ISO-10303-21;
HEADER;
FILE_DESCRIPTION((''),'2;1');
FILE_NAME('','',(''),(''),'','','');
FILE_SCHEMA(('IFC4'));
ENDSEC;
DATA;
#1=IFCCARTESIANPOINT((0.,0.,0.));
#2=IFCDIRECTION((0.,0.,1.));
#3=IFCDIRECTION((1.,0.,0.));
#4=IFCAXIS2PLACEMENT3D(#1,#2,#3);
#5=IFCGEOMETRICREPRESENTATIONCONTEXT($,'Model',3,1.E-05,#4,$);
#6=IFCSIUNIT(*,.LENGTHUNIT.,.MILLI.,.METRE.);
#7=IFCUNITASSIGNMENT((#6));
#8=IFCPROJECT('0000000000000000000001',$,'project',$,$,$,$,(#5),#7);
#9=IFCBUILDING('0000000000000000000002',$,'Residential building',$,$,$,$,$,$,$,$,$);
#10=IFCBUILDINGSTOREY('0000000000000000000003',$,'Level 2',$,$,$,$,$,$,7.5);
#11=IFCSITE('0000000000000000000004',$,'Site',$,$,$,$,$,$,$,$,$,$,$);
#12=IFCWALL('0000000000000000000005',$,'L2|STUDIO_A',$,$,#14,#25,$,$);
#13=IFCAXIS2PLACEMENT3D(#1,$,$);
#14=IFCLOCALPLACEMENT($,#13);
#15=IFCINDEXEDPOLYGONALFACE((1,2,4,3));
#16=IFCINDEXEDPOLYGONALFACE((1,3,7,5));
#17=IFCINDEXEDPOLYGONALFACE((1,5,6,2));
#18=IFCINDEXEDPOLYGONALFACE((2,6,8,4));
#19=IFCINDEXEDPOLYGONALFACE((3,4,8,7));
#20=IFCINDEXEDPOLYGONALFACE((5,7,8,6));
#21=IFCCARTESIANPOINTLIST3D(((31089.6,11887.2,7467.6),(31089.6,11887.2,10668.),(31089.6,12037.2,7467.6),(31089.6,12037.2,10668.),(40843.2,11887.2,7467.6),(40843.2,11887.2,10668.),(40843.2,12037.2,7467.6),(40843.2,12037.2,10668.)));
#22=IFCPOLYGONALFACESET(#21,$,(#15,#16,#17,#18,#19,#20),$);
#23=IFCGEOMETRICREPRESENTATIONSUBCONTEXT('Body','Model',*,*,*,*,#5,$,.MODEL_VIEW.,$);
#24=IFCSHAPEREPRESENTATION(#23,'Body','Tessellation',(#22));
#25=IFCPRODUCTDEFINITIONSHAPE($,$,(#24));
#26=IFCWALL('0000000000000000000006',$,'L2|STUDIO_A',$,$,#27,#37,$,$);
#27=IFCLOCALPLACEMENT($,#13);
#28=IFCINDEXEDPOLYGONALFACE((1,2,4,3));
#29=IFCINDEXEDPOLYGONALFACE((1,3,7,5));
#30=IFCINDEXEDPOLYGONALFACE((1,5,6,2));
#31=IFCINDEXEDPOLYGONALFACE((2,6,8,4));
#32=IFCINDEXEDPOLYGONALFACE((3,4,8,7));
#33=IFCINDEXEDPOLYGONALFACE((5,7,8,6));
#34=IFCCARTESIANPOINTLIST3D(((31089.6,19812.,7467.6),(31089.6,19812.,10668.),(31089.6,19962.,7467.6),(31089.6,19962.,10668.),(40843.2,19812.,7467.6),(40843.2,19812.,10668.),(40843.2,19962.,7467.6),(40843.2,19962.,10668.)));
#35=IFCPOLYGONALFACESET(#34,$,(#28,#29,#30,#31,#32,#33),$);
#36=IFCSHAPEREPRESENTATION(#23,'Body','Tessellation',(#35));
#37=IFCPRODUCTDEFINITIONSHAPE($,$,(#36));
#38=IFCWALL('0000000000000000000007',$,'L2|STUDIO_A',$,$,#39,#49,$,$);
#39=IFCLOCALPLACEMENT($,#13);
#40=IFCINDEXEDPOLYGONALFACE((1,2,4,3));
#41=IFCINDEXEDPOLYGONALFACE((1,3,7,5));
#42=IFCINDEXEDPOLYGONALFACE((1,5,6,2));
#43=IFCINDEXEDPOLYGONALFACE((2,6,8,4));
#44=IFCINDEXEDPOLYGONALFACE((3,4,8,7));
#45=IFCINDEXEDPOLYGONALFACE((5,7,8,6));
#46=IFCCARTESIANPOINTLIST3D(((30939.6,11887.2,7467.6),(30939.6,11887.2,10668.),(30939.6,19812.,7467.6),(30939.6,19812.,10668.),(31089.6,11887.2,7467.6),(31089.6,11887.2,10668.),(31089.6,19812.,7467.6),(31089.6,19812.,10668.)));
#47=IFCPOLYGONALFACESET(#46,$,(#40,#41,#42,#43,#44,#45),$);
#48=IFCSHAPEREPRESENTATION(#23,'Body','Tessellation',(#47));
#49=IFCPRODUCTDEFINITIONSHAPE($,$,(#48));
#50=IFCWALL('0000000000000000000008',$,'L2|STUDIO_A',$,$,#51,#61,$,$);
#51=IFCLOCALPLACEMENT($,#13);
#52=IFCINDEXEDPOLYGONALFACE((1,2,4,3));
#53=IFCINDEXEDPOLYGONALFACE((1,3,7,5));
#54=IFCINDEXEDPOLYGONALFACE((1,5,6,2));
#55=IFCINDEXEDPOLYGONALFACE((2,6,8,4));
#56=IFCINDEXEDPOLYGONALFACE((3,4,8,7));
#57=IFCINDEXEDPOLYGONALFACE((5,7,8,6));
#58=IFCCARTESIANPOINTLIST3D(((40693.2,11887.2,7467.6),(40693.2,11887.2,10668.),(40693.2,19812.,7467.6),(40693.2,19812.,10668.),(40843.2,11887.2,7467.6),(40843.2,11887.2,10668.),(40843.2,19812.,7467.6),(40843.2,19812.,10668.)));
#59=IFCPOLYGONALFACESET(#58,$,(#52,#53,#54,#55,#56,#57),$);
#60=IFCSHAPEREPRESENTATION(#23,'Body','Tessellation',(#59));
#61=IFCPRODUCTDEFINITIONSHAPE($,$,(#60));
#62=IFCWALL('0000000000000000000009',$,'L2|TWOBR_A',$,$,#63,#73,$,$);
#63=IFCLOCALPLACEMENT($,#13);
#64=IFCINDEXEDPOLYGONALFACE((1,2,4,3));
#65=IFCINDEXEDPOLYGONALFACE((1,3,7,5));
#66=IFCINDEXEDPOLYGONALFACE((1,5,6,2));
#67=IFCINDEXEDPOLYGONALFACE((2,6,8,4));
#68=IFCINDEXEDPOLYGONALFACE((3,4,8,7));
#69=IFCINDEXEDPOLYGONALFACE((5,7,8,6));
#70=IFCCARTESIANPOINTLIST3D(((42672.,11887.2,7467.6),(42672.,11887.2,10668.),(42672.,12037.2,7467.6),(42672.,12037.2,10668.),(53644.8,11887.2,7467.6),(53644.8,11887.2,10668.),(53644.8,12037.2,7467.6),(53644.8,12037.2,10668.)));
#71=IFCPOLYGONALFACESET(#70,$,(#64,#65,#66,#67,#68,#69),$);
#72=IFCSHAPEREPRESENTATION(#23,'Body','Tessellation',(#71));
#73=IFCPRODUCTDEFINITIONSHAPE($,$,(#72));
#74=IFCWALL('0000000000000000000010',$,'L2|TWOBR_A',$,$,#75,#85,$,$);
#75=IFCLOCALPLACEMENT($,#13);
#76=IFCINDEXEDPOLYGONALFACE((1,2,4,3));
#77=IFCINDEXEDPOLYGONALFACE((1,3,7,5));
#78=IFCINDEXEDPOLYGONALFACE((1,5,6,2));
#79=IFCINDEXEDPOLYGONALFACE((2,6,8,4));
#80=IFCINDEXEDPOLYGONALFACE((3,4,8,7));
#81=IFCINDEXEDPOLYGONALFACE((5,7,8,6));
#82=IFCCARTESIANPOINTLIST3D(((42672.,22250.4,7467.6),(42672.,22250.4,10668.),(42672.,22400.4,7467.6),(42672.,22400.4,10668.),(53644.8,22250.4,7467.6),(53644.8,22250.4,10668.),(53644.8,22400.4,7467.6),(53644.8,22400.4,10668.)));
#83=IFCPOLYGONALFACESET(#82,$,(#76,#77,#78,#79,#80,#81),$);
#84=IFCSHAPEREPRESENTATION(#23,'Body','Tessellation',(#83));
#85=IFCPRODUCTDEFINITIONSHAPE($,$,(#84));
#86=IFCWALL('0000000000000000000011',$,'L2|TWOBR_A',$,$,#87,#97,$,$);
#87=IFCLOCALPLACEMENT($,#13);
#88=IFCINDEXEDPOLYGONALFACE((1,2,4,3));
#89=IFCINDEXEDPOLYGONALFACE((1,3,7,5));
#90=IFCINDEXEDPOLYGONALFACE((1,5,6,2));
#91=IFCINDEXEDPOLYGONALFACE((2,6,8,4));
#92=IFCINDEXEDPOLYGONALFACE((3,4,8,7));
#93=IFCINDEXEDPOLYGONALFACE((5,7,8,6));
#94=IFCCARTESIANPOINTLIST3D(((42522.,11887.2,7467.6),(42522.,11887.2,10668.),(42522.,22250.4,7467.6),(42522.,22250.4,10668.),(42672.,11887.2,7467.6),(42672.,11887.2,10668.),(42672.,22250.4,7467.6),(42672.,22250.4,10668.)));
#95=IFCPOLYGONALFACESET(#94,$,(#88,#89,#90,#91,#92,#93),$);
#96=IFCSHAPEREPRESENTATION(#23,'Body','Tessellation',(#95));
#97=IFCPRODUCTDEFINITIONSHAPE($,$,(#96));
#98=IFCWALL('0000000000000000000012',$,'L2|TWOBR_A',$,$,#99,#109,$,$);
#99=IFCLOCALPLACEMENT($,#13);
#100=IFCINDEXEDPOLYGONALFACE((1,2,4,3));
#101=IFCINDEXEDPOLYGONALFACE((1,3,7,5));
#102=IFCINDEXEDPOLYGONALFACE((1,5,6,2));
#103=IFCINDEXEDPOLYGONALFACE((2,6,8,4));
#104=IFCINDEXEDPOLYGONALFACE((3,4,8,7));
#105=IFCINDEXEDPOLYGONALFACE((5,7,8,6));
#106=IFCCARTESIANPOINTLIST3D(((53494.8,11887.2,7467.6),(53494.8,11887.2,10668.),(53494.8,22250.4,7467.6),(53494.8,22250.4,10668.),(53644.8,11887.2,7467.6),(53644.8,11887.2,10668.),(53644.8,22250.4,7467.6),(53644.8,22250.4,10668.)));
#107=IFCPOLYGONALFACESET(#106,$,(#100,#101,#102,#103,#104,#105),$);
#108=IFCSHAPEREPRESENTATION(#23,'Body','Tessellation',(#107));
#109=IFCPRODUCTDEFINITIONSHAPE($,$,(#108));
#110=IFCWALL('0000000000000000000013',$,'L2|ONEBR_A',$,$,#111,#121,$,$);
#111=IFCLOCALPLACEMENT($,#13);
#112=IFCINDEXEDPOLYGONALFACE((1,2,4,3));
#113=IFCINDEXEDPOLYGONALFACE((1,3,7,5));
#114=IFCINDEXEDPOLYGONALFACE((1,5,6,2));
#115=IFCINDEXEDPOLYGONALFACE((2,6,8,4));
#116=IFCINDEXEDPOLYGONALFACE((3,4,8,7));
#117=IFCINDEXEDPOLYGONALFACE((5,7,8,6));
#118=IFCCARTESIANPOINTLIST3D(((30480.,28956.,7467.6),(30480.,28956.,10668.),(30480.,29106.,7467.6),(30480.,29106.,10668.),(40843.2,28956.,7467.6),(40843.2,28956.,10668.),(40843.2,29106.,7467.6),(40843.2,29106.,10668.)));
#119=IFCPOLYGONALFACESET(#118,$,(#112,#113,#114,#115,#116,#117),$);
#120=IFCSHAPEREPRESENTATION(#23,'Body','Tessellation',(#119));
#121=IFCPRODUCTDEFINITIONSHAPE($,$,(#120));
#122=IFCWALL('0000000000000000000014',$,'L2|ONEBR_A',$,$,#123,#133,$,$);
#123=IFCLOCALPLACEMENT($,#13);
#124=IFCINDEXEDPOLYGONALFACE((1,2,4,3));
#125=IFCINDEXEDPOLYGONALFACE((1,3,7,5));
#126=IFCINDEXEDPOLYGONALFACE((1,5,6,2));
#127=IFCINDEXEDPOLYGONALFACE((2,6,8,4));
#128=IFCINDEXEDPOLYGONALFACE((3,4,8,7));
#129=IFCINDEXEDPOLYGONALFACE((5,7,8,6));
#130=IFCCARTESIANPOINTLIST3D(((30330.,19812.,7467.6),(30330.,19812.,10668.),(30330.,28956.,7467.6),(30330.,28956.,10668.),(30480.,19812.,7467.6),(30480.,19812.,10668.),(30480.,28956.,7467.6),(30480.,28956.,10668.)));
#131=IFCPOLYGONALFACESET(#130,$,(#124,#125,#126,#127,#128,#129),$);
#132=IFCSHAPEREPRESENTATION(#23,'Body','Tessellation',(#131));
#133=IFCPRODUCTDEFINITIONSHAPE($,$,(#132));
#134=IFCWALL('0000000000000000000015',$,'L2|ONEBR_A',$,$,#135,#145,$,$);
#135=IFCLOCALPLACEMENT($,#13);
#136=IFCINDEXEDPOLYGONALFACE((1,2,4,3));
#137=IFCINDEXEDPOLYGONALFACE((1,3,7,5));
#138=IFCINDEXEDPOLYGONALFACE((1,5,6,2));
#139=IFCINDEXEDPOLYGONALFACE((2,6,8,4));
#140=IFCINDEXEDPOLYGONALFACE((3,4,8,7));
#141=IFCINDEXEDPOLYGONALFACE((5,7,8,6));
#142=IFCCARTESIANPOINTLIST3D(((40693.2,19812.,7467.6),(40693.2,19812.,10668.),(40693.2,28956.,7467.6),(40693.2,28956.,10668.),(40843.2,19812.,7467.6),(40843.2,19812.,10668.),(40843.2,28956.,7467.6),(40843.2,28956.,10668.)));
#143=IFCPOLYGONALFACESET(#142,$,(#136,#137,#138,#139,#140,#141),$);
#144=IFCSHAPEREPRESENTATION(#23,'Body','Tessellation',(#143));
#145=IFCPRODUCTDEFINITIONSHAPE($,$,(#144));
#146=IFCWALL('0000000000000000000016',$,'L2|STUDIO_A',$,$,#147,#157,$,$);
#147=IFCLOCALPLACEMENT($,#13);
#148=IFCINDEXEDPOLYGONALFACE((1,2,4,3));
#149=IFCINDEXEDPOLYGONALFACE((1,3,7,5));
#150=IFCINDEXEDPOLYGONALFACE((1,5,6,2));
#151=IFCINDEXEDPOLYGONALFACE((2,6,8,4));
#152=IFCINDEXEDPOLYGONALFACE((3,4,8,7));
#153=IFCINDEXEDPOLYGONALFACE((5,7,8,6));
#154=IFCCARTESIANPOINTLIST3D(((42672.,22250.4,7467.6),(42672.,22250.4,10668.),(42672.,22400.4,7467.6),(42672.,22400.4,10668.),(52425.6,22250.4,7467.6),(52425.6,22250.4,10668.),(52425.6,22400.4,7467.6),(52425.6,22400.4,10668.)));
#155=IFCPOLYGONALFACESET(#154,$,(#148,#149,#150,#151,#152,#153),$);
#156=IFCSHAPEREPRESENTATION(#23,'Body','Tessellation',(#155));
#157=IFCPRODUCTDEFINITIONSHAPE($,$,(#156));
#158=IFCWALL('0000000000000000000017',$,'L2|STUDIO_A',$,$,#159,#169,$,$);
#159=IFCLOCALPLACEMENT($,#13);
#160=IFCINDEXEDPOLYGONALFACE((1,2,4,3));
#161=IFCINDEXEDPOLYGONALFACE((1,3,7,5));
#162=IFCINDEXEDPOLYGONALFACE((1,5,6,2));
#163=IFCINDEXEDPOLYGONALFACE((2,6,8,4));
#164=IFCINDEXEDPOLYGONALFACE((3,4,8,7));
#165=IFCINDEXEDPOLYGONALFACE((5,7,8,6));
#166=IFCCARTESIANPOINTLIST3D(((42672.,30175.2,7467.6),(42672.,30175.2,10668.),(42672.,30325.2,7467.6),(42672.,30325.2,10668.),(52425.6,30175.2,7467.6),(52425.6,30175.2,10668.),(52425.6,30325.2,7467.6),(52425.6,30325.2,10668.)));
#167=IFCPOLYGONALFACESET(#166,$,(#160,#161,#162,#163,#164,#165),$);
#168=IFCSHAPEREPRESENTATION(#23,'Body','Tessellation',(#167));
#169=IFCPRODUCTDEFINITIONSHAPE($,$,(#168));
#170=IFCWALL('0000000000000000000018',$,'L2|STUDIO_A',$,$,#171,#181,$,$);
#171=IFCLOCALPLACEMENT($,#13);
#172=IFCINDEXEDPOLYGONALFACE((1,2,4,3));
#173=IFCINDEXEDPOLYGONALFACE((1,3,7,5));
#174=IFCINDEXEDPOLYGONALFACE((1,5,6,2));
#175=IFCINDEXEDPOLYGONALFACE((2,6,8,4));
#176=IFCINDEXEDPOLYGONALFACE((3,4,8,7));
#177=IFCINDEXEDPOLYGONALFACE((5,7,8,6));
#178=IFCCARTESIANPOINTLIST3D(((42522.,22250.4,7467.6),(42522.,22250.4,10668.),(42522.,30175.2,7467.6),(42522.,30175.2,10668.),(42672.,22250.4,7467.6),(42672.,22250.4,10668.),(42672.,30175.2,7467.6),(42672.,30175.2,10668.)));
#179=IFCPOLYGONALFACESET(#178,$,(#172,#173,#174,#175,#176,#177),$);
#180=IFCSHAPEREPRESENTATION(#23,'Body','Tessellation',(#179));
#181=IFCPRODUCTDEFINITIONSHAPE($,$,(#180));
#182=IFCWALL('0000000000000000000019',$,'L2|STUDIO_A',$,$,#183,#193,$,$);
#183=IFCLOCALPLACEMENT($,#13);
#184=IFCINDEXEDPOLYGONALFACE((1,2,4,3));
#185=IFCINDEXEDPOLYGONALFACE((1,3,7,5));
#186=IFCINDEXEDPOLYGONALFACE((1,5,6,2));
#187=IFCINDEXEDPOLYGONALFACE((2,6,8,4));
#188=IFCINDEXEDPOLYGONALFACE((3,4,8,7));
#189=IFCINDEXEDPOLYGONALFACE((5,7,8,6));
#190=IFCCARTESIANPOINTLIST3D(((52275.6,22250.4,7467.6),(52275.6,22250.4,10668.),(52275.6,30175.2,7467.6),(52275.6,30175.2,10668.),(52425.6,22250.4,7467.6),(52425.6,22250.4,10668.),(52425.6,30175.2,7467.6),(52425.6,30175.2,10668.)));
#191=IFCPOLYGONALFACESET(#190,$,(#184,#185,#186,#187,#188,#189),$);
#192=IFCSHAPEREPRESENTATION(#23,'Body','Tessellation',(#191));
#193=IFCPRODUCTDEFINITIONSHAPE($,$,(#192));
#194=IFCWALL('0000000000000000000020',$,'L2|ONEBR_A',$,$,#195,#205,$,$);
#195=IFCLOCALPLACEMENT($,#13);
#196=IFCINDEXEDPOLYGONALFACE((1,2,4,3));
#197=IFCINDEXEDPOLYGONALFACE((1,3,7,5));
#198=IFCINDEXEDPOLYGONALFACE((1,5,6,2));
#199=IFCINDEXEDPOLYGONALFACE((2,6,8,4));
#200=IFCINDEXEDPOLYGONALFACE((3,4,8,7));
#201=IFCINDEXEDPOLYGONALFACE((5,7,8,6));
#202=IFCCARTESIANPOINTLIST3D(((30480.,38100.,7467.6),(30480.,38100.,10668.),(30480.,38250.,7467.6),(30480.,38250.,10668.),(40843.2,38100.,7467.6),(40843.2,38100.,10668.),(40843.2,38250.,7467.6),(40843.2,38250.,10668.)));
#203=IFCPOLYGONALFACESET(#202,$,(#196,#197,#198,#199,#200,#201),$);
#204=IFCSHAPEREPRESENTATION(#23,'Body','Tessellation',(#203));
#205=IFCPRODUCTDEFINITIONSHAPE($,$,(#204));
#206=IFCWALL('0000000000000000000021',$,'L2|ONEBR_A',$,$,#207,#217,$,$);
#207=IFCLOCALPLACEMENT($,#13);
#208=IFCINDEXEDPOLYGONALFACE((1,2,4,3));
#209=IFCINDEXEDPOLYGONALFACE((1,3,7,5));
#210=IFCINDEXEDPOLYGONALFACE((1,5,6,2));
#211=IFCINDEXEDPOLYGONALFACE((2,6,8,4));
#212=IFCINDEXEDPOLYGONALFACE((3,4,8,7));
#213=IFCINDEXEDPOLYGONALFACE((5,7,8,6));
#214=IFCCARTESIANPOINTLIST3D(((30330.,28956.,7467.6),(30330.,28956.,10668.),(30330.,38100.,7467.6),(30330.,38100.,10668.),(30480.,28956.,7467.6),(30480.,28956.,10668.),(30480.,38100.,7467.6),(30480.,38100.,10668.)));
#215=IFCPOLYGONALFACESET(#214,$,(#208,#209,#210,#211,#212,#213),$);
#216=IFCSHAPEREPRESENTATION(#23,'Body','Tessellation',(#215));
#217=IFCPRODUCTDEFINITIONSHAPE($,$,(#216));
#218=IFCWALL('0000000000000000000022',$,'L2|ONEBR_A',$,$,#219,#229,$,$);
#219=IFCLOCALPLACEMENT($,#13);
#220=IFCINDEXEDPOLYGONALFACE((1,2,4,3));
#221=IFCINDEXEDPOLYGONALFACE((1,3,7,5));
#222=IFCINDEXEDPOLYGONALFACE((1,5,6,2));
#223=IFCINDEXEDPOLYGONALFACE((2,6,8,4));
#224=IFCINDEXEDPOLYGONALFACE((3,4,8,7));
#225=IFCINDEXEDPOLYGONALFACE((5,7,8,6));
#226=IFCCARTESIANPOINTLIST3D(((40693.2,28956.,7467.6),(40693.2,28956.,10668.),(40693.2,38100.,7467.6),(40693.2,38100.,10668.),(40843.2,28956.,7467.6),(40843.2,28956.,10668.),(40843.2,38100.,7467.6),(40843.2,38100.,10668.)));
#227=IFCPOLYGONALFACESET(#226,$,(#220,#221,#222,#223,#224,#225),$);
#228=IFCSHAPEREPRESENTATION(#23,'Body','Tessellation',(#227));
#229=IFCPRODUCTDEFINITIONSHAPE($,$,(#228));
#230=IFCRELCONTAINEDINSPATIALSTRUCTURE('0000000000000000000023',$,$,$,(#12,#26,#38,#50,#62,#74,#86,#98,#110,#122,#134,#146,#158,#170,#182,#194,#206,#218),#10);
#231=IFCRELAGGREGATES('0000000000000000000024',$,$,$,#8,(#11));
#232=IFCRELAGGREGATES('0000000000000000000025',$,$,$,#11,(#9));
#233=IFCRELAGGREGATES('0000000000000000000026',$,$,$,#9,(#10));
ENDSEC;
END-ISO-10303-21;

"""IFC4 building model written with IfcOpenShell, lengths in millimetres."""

from ifc_helpers import new_model, si_unit, frame, origin_with_axes, place, context, subcontext, project, spatial, indexed_curve, outline, extrude, element, save


model = new_model("IFC4")

# Units and contexts
model_context = context("Model", 3, precision=1e-05, world=origin_with_axes())
body_context = subcontext(model_context, "Body", "Model", "MODEL_VIEW")
ifc_project = project(units=[si_unit("LENGTHUNIT", "METRE", prefix="MILLI")], contexts=[model_context])

# Site, building, storey
site = spatial("IfcSite", under=ifc_project, Name="Site")
building = spatial("IfcBuilding", under=site, Name="Residential building")
storey = spatial("IfcBuildingStorey", under=building, Name="Level 2", Elevation=7.5)

# Walls
for number, where, z_axis, x_axis, name in (
    (1, (31089.6, 11887.2, 7467.6), (0.0, 0.0, 1.0), (1.0, 0.0, 0.0), "L2|STUDIO_A"),
    (2, (31089.6, 19812.0, 7467.6), (0.0, 0.0, 1.0), (1.0, 0.0, 0.0), "L2|STUDIO_A"),
):
    element("IfcWall", number, at=place(None, frame(where, z_axis=z_axis, x_axis=x_axis)), inside=storey, Name=name, context=body_context, shape_type="SweptSolid", body=[
        extrude(outline(indexed_curve([(0.0, 0.0), (0.0, 150.0), (9753.6, 150.0), (9753.6, 0.0), (0.0, 0.0)], self_intersect=False)), origin_with_axes(), (0.0, 0.0, 1.0), 3200.4),
    ])
for number, where, z_axis, x_axis, name in (
    (3, (31089.6, 11887.2, 7467.6), (0.0, 0.0, 1.0), (0.0, 1.0, 0.0), "L2|STUDIO_A"),
    (4, (40843.2, 11887.2, 7467.6), (0.0, 0.0, 1.0), (0.0, 1.0, 0.0), "L2|STUDIO_A"),
):
    element("IfcWall", number, at=place(None, frame(where, z_axis=z_axis, x_axis=x_axis)), inside=storey, Name=name, context=body_context, shape_type="SweptSolid", body=[
        extrude(outline(indexed_curve([(0.0, 0.0), (0.0, 150.0), (7924.8, 150.0), (7924.8, 0.0), (0.0, 0.0)], self_intersect=False)), origin_with_axes(), (0.0, 0.0, 1.0), 3200.4),
    ])
for number, where, z_axis, x_axis, name in (
    (5, (42672.0, 11887.2, 7467.6), (0.0, 0.0, 1.0), (1.0, 0.0, 0.0), "L2|TWOBR_A"),
    (6, (42672.0, 22250.4, 7467.6), (0.0, 0.0, 1.0), (1.0, 0.0, 0.0), "L2|TWOBR_A"),
):
    element("IfcWall", number, at=place(None, frame(where, z_axis=z_axis, x_axis=x_axis)), inside=storey, Name=name, context=body_context, shape_type="SweptSolid", body=[
        extrude(outline(indexed_curve([(0.0, 0.0), (0.0, 150.0), (10972.8, 150.0), (10972.8, 0.0), (0.0, 0.0)], self_intersect=False)), origin_with_axes(), (0.0, 0.0, 1.0), 3200.4),
    ])
for number, where, z_axis, x_axis, name in (
    (7, (42672.0, 11887.2, 7467.6), (0.0, 0.0, 1.0), (0.0, 1.0, 0.0), "L2|TWOBR_A"),
    (8, (53644.8, 11887.2, 7467.6), (0.0, 0.0, 1.0), (0.0, 1.0, 0.0), "L2|TWOBR_A"),
    (9, (30480.0, 28956.0, 7467.6), (0.0, 0.0, 1.0), (1.0, 0.0, 0.0), "L2|ONEBR_A"),
):
    element("IfcWall", number, at=place(None, frame(where, z_axis=z_axis, x_axis=x_axis)), inside=storey, Name=name, context=body_context, shape_type="SweptSolid", body=[
        extrude(outline(indexed_curve([(0.0, 0.0), (0.0, 150.0), (10363.2, 150.0), (10363.2, 0.0), (0.0, 0.0)], self_intersect=False)), origin_with_axes(), (0.0, 0.0, 1.0), 3200.4),
    ])
for number, where, z_axis, x_axis, name in (
    (10, (30480.0, 19812.0, 7467.6), (0.0, 0.0, 1.0), (0.0, 1.0, 0.0), "L2|ONEBR_A"),
    (11, (40843.2, 19812.0, 7467.6), (0.0, 0.0, 1.0), (0.0, 1.0, 0.0), "L2|ONEBR_A"),
):
    element("IfcWall", number, at=place(None, frame(where, z_axis=z_axis, x_axis=x_axis)), inside=storey, Name=name, context=body_context, shape_type="SweptSolid", body=[
        extrude(outline(indexed_curve([(0.0, 0.0), (0.0, 150.0), (9144.0, 150.0), (9144.0, 0.0), (0.0, 0.0)], self_intersect=False)), origin_with_axes(), (0.0, 0.0, 1.0), 3200.4),
    ])
for number, where, z_axis, x_axis, name in (
    (12, (42672.0, 22250.4, 7467.6), (0.0, 0.0, 1.0), (1.0, 0.0, 0.0), "L2|STUDIO_A"),
    (13, (42672.0, 30175.2, 7467.6), (0.0, 0.0, 1.0), (1.0, 0.0, 0.0), "L2|STUDIO_A"),
):
    element("IfcWall", number, at=place(None, frame(where, z_axis=z_axis, x_axis=x_axis)), inside=storey, Name=name, context=body_context, shape_type="SweptSolid", body=[
        extrude(outline(indexed_curve([(0.0, 0.0), (0.0, 150.0), (9753.6, 150.0), (9753.6, 0.0), (0.0, 0.0)], self_intersect=False)), origin_with_axes(), (0.0, 0.0, 1.0), 3200.4),
    ])
for number, where, z_axis, x_axis, name in (
    (14, (42672.0, 22250.4, 7467.6), (0.0, 0.0, 1.0), (0.0, 1.0, 0.0), "L2|STUDIO_A"),
    (15, (52425.6, 22250.4, 7467.6), (0.0, 0.0, 1.0), (0.0, 1.0, 0.0), "L2|STUDIO_A"),
):
    element("IfcWall", number, at=place(None, frame(where, z_axis=z_axis, x_axis=x_axis)), inside=storey, Name=name, context=body_context, shape_type="SweptSolid", body=[
        extrude(outline(indexed_curve([(0.0, 0.0), (0.0, 150.0), (7924.8, 150.0), (7924.8, 0.0), (0.0, 0.0)], self_intersect=False)), origin_with_axes(), (0.0, 0.0, 1.0), 3200.4),
    ])
for number, where, z_axis, x_axis, name in (
    (16, (30480.0, 38100.0, 7467.6), (0.0, 0.0, 1.0), (1.0, 0.0, 0.0), "L2|ONEBR_A"),
):
    element("IfcWall", number, at=place(None, frame(where, z_axis=z_axis, x_axis=x_axis)), inside=storey, Name=name, context=body_context, shape_type="SweptSolid", body=[
        extrude(outline(indexed_curve([(0.0, 0.0), (0.0, 150.0), (10363.2, 150.0), (10363.2, 0.0), (0.0, 0.0)], self_intersect=False)), origin_with_axes(), (0.0, 0.0, 1.0), 3200.4),
    ])
for number, where, z_axis, x_axis, name in (
    (17, (30480.0, 28956.0, 7467.6), (0.0, 0.0, 1.0), (0.0, 1.0, 0.0), "L2|ONEBR_A"),
    (18, (40843.2, 28956.0, 7467.6), (0.0, 0.0, 1.0), (0.0, 1.0, 0.0), "L2|ONEBR_A"),
):
    element("IfcWall", number, at=place(None, frame(where, z_axis=z_axis, x_axis=x_axis)), inside=storey, Name=name, context=body_context, shape_type="SweptSolid", body=[
        extrude(outline(indexed_curve([(0.0, 0.0), (0.0, 150.0), (9144.0, 150.0), (9144.0, 0.0), (0.0, 0.0)], self_intersect=False)), origin_with_axes(), (0.0, 0.0, 1.0), 3200.4),
    ])

save(model, "model.ifc")
